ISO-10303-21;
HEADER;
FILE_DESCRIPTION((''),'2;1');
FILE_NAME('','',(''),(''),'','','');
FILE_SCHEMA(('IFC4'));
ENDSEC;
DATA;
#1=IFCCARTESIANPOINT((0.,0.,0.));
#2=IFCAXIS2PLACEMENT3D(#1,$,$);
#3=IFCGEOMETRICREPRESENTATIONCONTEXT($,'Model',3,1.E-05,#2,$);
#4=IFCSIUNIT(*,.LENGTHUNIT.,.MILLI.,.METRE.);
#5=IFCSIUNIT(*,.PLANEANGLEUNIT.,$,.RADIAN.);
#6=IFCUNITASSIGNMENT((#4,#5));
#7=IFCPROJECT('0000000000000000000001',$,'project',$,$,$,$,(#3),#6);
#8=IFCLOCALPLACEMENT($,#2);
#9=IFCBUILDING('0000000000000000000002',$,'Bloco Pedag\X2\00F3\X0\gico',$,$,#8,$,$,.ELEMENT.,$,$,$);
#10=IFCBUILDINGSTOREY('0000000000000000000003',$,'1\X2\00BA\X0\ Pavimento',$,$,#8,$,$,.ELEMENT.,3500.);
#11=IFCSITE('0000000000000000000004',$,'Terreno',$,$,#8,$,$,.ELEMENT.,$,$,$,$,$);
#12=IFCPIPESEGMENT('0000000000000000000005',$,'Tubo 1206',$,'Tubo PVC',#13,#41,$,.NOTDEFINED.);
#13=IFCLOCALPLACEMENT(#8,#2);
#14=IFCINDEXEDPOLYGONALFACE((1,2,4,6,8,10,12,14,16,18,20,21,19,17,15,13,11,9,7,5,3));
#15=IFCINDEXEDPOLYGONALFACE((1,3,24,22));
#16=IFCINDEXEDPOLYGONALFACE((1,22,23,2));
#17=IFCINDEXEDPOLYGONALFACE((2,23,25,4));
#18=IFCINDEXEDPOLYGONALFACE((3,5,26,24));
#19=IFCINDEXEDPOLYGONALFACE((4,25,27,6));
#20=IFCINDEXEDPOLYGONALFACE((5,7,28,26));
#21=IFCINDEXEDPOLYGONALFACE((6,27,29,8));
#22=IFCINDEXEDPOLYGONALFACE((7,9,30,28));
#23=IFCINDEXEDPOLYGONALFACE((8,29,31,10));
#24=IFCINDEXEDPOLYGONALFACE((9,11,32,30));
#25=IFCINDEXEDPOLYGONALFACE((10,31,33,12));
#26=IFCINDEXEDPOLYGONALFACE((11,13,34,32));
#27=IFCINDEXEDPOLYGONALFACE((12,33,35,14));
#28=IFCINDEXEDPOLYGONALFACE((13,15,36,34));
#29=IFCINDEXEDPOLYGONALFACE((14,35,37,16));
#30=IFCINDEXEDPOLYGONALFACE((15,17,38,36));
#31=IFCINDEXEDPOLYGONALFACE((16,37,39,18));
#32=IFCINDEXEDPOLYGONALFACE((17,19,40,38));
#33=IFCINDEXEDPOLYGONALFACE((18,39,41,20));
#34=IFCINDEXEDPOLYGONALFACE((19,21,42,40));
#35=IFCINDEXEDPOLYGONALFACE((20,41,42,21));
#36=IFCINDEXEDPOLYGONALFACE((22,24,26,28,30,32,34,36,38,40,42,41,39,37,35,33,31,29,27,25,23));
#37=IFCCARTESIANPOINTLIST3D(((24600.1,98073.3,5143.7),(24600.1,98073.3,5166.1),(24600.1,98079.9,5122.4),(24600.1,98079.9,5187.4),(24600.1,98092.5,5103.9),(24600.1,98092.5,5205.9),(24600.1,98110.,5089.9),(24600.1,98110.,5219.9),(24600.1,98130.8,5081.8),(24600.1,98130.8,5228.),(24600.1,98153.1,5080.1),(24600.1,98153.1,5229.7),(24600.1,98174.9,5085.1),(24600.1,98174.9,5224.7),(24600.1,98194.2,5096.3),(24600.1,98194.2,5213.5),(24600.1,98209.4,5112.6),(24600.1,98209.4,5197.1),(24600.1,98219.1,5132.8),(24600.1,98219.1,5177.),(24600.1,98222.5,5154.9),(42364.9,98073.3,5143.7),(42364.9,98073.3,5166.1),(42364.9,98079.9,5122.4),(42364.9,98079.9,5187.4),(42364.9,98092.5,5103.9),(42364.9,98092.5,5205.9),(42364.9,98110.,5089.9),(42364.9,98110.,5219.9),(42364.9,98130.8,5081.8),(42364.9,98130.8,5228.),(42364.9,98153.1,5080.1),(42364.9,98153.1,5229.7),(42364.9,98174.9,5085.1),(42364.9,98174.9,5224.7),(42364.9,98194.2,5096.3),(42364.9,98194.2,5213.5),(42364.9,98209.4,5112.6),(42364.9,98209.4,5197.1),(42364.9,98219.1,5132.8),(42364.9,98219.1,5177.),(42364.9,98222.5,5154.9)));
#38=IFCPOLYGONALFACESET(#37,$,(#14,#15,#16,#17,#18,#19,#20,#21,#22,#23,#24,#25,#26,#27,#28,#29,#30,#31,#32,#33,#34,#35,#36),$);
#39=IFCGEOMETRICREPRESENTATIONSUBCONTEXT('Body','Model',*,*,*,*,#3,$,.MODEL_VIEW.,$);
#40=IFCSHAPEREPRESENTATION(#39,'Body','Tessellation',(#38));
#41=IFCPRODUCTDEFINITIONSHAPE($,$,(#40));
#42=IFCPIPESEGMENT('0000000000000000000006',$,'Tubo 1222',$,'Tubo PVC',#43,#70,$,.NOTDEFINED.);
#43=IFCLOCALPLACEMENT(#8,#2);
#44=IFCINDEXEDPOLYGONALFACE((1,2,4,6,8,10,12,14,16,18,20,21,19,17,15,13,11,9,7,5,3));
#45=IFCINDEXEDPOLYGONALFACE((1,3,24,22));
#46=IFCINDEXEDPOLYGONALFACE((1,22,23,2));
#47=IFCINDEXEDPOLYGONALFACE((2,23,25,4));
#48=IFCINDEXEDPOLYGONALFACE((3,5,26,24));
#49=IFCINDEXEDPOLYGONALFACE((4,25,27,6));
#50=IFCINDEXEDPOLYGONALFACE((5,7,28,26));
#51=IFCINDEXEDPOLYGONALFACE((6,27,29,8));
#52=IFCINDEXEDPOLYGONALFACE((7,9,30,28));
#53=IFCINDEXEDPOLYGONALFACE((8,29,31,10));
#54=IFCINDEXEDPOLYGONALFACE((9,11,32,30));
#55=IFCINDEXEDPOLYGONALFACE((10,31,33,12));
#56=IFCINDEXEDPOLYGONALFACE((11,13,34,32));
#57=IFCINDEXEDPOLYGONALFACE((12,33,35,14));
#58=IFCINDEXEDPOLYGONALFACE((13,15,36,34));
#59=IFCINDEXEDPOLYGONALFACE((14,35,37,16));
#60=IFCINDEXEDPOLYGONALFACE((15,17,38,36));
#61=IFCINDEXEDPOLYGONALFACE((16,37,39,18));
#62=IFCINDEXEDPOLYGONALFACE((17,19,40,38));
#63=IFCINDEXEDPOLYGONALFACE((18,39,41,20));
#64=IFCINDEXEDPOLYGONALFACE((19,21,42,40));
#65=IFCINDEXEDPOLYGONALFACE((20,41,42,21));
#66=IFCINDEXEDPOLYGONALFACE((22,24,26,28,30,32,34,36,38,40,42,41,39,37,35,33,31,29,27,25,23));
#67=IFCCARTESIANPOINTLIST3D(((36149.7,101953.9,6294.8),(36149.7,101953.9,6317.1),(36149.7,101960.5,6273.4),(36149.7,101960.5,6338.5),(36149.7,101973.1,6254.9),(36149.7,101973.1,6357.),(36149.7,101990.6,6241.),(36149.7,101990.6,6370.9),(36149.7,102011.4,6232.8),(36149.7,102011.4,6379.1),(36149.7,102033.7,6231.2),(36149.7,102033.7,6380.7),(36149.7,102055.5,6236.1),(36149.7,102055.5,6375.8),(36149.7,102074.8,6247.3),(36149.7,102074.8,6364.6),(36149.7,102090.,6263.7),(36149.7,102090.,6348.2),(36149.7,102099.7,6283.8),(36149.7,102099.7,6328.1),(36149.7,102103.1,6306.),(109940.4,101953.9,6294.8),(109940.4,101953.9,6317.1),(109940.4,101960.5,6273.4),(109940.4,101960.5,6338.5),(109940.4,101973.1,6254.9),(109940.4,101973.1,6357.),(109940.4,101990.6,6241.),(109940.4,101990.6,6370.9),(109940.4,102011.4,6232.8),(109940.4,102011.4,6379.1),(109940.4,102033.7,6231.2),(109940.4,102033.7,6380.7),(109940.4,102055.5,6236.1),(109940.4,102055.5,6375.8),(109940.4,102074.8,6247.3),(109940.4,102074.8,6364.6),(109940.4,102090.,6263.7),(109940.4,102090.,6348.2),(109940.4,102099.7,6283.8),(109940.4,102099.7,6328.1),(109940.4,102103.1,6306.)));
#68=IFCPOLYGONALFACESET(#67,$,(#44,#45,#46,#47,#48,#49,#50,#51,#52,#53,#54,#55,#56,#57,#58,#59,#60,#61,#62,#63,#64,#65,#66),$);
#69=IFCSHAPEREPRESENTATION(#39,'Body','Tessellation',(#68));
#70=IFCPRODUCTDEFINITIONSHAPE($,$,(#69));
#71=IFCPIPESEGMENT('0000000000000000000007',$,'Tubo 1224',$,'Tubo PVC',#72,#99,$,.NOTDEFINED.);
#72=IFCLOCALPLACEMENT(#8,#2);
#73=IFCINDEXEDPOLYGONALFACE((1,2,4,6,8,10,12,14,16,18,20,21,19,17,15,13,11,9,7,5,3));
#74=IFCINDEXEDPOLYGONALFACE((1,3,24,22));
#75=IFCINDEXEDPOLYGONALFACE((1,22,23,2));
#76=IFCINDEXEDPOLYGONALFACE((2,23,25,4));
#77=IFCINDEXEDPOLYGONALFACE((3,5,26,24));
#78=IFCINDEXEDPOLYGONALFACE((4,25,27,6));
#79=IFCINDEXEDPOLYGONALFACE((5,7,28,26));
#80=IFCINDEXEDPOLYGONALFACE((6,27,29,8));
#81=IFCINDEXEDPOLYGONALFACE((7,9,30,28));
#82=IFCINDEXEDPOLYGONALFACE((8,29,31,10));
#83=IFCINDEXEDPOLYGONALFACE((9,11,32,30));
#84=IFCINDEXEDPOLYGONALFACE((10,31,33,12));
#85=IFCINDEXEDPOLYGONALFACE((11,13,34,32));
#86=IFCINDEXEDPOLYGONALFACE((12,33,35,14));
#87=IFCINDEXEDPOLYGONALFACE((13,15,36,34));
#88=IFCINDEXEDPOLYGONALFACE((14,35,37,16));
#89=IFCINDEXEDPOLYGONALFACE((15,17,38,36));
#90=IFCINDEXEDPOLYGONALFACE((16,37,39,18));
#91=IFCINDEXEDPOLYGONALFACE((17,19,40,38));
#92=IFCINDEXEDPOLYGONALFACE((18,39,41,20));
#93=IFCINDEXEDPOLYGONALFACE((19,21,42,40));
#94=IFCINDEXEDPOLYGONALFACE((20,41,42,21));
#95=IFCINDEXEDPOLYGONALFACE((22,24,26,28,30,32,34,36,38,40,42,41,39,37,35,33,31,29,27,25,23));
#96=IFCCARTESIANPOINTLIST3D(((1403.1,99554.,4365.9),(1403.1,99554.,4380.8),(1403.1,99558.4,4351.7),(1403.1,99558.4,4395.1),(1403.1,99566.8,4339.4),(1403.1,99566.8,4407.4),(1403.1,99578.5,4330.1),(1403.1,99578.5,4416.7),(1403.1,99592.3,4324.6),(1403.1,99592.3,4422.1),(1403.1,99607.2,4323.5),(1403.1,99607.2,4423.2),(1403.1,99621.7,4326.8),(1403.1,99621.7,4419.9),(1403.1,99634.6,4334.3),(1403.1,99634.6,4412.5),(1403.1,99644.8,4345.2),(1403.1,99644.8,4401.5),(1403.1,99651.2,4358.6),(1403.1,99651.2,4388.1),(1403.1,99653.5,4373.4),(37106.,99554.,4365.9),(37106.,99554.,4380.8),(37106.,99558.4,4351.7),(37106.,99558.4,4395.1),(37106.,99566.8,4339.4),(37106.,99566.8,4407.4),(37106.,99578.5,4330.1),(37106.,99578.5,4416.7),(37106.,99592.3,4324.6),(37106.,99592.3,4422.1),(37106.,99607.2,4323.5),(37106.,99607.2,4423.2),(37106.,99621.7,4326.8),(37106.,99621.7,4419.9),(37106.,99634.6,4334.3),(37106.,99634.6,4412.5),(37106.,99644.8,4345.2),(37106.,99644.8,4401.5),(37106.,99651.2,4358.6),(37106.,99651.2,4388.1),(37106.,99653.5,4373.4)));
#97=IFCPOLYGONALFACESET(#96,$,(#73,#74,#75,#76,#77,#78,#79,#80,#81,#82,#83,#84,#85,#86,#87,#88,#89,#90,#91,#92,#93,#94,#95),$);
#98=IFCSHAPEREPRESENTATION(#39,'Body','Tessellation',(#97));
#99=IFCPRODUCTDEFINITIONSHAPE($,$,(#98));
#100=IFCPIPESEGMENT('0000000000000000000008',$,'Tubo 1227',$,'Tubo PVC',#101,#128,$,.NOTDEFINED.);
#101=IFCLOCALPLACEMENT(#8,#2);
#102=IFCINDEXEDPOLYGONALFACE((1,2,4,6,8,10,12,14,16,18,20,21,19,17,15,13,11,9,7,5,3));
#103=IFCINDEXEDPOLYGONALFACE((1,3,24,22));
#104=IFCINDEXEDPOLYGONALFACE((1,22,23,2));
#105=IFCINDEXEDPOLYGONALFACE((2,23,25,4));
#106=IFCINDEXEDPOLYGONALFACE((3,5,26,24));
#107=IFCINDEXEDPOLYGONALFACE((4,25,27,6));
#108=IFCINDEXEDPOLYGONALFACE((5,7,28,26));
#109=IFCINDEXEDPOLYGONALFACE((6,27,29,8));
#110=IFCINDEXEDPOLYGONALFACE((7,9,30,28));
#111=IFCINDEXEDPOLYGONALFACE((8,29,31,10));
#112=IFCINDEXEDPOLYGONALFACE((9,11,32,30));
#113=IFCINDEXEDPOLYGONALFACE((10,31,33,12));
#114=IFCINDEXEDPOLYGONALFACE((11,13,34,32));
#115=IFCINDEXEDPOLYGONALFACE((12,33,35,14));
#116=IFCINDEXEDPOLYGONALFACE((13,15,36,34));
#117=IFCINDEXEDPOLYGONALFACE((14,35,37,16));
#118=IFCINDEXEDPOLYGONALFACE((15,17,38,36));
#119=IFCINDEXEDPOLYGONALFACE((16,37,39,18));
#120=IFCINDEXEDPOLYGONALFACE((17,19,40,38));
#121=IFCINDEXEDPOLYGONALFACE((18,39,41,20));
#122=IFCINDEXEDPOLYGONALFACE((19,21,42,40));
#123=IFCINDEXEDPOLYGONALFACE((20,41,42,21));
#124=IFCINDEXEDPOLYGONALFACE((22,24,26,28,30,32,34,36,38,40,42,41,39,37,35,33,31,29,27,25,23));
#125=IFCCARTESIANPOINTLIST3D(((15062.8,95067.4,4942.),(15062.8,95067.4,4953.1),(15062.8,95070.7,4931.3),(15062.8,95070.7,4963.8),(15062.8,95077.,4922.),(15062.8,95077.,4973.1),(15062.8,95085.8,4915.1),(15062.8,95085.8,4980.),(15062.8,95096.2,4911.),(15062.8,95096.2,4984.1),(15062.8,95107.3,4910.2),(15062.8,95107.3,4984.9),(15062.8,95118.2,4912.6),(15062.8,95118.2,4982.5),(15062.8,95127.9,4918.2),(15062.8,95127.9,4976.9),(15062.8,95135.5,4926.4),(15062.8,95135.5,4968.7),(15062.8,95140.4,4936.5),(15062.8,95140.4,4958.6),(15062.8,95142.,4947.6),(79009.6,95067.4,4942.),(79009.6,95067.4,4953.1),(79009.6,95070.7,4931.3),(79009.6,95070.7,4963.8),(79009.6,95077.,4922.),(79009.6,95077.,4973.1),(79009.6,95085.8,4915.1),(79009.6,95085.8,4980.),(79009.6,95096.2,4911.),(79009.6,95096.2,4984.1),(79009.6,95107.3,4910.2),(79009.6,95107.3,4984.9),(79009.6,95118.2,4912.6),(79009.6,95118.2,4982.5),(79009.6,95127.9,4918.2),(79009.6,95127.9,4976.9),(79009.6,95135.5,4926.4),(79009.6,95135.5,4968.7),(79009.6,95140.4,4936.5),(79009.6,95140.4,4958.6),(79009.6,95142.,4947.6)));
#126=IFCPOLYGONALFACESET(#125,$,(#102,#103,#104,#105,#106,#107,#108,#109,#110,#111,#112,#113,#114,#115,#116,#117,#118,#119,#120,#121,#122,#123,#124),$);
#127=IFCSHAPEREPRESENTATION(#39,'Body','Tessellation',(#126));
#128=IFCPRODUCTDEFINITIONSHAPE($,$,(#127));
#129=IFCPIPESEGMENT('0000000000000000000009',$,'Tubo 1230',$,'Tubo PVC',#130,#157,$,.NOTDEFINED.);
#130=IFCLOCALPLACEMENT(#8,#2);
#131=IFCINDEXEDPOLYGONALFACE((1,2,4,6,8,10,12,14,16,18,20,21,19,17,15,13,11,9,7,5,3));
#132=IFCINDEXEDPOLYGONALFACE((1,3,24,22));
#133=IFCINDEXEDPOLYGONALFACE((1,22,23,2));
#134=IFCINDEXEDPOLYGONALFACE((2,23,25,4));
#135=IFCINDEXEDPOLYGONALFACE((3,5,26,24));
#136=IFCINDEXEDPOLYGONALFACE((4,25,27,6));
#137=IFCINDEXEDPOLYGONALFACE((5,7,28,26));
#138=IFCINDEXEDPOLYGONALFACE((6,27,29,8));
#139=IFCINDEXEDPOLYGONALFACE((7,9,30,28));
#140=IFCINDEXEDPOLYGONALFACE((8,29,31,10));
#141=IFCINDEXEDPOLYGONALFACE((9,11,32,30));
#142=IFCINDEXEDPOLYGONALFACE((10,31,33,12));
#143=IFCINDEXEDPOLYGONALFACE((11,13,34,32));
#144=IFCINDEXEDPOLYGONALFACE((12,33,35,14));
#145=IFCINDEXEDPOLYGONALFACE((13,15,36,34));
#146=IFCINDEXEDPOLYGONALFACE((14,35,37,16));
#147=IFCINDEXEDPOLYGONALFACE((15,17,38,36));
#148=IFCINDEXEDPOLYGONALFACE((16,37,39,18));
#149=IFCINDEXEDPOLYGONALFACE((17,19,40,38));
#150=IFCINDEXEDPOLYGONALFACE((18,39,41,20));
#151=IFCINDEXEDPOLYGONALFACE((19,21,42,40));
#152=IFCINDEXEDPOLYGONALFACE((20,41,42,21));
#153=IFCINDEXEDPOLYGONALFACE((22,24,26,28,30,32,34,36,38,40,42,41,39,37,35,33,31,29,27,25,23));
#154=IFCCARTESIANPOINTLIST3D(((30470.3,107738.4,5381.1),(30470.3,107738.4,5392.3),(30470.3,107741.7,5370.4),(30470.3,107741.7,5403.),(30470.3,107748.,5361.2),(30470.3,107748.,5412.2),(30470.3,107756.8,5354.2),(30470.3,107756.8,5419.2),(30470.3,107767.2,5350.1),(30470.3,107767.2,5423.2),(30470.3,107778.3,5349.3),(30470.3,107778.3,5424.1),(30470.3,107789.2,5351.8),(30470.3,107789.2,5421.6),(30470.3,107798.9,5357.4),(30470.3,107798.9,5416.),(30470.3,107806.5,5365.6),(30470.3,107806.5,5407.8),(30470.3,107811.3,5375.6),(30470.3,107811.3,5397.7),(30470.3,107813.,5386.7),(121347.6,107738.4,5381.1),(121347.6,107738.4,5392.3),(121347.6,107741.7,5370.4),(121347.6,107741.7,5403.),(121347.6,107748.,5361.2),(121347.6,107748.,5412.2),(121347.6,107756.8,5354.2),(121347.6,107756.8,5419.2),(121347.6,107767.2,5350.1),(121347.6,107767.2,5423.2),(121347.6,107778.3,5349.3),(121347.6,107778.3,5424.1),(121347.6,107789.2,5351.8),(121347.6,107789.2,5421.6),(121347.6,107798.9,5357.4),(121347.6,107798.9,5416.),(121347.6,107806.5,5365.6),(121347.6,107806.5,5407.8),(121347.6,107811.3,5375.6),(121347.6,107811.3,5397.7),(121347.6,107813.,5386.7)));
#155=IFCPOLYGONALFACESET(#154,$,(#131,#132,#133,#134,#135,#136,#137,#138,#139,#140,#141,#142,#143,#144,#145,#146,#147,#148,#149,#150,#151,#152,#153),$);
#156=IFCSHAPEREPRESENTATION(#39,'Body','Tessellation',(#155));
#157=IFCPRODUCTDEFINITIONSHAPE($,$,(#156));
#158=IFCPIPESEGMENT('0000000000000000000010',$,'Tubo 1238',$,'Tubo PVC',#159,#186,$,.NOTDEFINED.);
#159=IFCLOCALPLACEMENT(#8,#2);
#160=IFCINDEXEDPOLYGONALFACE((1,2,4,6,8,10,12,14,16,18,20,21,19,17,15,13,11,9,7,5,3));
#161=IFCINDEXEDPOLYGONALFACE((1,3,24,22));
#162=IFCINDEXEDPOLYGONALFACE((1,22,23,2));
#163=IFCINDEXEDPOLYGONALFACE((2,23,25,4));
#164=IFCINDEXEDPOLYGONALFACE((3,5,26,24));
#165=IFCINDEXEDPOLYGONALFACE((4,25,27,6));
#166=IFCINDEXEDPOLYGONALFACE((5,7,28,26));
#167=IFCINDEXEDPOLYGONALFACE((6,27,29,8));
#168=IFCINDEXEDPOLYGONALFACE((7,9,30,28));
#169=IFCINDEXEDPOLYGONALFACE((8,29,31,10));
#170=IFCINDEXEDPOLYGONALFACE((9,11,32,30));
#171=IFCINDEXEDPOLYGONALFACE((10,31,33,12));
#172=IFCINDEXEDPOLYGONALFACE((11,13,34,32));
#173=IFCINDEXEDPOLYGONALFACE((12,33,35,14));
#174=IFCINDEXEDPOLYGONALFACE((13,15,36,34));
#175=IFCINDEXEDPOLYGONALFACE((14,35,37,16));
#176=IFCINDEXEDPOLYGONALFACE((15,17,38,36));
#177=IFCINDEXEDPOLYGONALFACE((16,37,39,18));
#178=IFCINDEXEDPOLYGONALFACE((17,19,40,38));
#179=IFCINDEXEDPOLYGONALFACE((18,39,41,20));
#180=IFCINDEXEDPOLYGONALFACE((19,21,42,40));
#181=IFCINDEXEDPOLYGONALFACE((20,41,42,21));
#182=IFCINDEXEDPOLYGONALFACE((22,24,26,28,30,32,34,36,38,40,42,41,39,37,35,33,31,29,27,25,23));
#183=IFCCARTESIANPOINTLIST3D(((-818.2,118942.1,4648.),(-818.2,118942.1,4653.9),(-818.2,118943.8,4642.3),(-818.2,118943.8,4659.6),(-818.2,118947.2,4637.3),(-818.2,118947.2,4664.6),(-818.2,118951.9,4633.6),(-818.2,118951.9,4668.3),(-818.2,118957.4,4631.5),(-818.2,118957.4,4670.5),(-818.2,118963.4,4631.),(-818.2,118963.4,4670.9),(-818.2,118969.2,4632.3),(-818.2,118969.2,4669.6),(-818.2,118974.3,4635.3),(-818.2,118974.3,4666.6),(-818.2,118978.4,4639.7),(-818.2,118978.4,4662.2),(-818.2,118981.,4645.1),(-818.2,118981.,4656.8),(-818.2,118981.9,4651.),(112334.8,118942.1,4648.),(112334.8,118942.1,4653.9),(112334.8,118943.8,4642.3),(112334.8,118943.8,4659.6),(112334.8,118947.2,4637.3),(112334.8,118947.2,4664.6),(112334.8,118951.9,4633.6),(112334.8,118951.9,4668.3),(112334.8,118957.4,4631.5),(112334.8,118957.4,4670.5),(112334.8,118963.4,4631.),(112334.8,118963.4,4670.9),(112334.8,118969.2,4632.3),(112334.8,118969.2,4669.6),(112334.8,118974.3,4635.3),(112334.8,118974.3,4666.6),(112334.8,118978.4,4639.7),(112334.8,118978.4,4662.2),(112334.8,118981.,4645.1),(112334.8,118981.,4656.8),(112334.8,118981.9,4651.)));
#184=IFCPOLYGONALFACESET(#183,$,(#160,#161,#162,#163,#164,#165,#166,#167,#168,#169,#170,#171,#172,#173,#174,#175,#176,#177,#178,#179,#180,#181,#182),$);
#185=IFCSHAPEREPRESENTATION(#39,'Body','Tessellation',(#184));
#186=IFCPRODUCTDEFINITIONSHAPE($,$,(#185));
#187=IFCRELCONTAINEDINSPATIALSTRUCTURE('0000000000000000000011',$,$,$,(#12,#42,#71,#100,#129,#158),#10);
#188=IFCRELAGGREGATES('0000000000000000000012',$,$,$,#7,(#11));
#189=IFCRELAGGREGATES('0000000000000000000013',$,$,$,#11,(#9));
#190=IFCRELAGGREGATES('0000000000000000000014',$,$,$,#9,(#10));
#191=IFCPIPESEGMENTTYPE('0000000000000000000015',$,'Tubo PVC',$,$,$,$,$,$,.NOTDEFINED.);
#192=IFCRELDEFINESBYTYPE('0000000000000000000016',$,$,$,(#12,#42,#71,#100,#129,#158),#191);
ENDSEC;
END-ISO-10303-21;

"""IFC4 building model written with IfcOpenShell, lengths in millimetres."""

from ifc_helpers import new_model, si_unit, frame, origin, origin_2d, place, context, subcontext, project, spatial, circle, extrude, type_object, element, save


model = new_model("IFC4")

# Units and contexts
model_context = context("Model", 3, precision=1e-05, world=origin())
body_context = subcontext(model_context, "Body", "Model", "MODEL_VIEW")
ifc_project = project(units=[si_unit("LENGTHUNIT", "METRE", prefix="MILLI"), si_unit("PLANEANGLEUNIT", "RADIAN")], contexts=[model_context])

# Site, building, storey
placement = place(None, origin())
site = spatial("IfcSite", under=ifc_project, at=placement, Name="Terreno", CompositionType="ELEMENT")
building = spatial("IfcBuilding", under=site, at=placement, Name="Bloco Pedagógico", CompositionType="ELEMENT")
storey = spatial("IfcBuildingStorey", under=building, at=placement, Name="1º Pavimento", CompositionType="ELEMENT", Elevation=3500.0)

# Pipe segments
pipe_segment_type = type_object("IfcPipeSegmentType", Name="Tubo PVC", PredefinedType="NOTDEFINED")
pipe_segment_1_placement = place(None, frame((24600.1, 98147.5, 5154.9), z_axis=(1.0, 0.0, 0.0), x_axis=(0.0, 1.0, 0.0)))
element("IfcPipeSegment", 1, at=pipe_segment_1_placement, inside=storey, type_object=pipe_segment_type, Name="Tubo 1206", ObjectType="Tubo PVC", PredefinedType="NOTDEFINED", context=body_context, shape_type="SweptSolid", body=[
    extrude(circle(Radius=75.0, at=origin_2d()), None, (0.0, 0.0, 1.0), 17764.8),
])
pipe_segment_2_placement = place(None, frame((36149.7, 102028.1, 6306.0), z_axis=(1.0, 0.0, 0.0), x_axis=(0.0, 1.0, 0.0)))
element("IfcPipeSegment", 2, at=pipe_segment_2_placement, inside=storey, type_object=pipe_segment_type, Name="Tubo 1222", ObjectType="Tubo PVC", PredefinedType="NOTDEFINED", context=body_context, shape_type="SweptSolid", body=[
    extrude(circle(Radius=75.0, at=origin_2d()), None, (0.0, 0.0, 1.0), 73790.7),
])
pipe_segment_3_placement = place(None, frame((1403.1, 99603.5, 4373.4), z_axis=(1.0, 0.0, 0.0), x_axis=(0.0, 1.0, 0.0)))
element("IfcPipeSegment", 3, at=pipe_segment_3_placement, inside=storey, type_object=pipe_segment_type, Name="Tubo 1224", ObjectType="Tubo PVC", PredefinedType="NOTDEFINED", context=body_context, shape_type="SweptSolid", body=[
    extrude(circle(Radius=50.0, at=origin_2d()), None, (0.0, 0.0, 1.0), 35702.9),
])
pipe_segment_4_placement = place(None, frame((15062.8, 95104.5, 4947.6), z_axis=(1.0, 0.0, 0.0), x_axis=(0.0, 1.0, 0.0)))
element("IfcPipeSegment", 4, at=pipe_segment_4_placement, inside=storey, type_object=pipe_segment_type, Name="Tubo 1227", ObjectType="Tubo PVC", PredefinedType="NOTDEFINED", context=body_context, shape_type="SweptSolid", body=[
    extrude(circle(Radius=37.5, at=origin_2d()), None, (0.0, 0.0, 1.0), 63946.8),
])
pipe_segment_5_placement = place(None, frame((30470.3, 107775.5, 5386.7), z_axis=(1.0, 0.0, 0.0), x_axis=(0.0, 1.0, 0.0)))
element("IfcPipeSegment", 5, at=pipe_segment_5_placement, inside=storey, type_object=pipe_segment_type, Name="Tubo 1230", ObjectType="Tubo PVC", PredefinedType="NOTDEFINED", context=body_context, shape_type="SweptSolid", body=[
    extrude(circle(Radius=37.5, at=origin_2d()), None, (0.0, 0.0, 1.0), 90877.3),
])
pipe_segment_6_placement = place(None, frame((-818.2, 118961.9, 4651.0), z_axis=(1.0, 0.0, 0.0), x_axis=(0.0, 1.0, 0.0)))
element("IfcPipeSegment", 6, at=pipe_segment_6_placement, inside=storey, type_object=pipe_segment_type, Name="Tubo 1238", ObjectType="Tubo PVC", PredefinedType="NOTDEFINED", context=body_context, shape_type="SweptSolid", body=[
    extrude(circle(Radius=20.0, at=origin_2d()), None, (0.0, 0.0, 1.0), 113153.1),
])

save(model, "model.ifc")
